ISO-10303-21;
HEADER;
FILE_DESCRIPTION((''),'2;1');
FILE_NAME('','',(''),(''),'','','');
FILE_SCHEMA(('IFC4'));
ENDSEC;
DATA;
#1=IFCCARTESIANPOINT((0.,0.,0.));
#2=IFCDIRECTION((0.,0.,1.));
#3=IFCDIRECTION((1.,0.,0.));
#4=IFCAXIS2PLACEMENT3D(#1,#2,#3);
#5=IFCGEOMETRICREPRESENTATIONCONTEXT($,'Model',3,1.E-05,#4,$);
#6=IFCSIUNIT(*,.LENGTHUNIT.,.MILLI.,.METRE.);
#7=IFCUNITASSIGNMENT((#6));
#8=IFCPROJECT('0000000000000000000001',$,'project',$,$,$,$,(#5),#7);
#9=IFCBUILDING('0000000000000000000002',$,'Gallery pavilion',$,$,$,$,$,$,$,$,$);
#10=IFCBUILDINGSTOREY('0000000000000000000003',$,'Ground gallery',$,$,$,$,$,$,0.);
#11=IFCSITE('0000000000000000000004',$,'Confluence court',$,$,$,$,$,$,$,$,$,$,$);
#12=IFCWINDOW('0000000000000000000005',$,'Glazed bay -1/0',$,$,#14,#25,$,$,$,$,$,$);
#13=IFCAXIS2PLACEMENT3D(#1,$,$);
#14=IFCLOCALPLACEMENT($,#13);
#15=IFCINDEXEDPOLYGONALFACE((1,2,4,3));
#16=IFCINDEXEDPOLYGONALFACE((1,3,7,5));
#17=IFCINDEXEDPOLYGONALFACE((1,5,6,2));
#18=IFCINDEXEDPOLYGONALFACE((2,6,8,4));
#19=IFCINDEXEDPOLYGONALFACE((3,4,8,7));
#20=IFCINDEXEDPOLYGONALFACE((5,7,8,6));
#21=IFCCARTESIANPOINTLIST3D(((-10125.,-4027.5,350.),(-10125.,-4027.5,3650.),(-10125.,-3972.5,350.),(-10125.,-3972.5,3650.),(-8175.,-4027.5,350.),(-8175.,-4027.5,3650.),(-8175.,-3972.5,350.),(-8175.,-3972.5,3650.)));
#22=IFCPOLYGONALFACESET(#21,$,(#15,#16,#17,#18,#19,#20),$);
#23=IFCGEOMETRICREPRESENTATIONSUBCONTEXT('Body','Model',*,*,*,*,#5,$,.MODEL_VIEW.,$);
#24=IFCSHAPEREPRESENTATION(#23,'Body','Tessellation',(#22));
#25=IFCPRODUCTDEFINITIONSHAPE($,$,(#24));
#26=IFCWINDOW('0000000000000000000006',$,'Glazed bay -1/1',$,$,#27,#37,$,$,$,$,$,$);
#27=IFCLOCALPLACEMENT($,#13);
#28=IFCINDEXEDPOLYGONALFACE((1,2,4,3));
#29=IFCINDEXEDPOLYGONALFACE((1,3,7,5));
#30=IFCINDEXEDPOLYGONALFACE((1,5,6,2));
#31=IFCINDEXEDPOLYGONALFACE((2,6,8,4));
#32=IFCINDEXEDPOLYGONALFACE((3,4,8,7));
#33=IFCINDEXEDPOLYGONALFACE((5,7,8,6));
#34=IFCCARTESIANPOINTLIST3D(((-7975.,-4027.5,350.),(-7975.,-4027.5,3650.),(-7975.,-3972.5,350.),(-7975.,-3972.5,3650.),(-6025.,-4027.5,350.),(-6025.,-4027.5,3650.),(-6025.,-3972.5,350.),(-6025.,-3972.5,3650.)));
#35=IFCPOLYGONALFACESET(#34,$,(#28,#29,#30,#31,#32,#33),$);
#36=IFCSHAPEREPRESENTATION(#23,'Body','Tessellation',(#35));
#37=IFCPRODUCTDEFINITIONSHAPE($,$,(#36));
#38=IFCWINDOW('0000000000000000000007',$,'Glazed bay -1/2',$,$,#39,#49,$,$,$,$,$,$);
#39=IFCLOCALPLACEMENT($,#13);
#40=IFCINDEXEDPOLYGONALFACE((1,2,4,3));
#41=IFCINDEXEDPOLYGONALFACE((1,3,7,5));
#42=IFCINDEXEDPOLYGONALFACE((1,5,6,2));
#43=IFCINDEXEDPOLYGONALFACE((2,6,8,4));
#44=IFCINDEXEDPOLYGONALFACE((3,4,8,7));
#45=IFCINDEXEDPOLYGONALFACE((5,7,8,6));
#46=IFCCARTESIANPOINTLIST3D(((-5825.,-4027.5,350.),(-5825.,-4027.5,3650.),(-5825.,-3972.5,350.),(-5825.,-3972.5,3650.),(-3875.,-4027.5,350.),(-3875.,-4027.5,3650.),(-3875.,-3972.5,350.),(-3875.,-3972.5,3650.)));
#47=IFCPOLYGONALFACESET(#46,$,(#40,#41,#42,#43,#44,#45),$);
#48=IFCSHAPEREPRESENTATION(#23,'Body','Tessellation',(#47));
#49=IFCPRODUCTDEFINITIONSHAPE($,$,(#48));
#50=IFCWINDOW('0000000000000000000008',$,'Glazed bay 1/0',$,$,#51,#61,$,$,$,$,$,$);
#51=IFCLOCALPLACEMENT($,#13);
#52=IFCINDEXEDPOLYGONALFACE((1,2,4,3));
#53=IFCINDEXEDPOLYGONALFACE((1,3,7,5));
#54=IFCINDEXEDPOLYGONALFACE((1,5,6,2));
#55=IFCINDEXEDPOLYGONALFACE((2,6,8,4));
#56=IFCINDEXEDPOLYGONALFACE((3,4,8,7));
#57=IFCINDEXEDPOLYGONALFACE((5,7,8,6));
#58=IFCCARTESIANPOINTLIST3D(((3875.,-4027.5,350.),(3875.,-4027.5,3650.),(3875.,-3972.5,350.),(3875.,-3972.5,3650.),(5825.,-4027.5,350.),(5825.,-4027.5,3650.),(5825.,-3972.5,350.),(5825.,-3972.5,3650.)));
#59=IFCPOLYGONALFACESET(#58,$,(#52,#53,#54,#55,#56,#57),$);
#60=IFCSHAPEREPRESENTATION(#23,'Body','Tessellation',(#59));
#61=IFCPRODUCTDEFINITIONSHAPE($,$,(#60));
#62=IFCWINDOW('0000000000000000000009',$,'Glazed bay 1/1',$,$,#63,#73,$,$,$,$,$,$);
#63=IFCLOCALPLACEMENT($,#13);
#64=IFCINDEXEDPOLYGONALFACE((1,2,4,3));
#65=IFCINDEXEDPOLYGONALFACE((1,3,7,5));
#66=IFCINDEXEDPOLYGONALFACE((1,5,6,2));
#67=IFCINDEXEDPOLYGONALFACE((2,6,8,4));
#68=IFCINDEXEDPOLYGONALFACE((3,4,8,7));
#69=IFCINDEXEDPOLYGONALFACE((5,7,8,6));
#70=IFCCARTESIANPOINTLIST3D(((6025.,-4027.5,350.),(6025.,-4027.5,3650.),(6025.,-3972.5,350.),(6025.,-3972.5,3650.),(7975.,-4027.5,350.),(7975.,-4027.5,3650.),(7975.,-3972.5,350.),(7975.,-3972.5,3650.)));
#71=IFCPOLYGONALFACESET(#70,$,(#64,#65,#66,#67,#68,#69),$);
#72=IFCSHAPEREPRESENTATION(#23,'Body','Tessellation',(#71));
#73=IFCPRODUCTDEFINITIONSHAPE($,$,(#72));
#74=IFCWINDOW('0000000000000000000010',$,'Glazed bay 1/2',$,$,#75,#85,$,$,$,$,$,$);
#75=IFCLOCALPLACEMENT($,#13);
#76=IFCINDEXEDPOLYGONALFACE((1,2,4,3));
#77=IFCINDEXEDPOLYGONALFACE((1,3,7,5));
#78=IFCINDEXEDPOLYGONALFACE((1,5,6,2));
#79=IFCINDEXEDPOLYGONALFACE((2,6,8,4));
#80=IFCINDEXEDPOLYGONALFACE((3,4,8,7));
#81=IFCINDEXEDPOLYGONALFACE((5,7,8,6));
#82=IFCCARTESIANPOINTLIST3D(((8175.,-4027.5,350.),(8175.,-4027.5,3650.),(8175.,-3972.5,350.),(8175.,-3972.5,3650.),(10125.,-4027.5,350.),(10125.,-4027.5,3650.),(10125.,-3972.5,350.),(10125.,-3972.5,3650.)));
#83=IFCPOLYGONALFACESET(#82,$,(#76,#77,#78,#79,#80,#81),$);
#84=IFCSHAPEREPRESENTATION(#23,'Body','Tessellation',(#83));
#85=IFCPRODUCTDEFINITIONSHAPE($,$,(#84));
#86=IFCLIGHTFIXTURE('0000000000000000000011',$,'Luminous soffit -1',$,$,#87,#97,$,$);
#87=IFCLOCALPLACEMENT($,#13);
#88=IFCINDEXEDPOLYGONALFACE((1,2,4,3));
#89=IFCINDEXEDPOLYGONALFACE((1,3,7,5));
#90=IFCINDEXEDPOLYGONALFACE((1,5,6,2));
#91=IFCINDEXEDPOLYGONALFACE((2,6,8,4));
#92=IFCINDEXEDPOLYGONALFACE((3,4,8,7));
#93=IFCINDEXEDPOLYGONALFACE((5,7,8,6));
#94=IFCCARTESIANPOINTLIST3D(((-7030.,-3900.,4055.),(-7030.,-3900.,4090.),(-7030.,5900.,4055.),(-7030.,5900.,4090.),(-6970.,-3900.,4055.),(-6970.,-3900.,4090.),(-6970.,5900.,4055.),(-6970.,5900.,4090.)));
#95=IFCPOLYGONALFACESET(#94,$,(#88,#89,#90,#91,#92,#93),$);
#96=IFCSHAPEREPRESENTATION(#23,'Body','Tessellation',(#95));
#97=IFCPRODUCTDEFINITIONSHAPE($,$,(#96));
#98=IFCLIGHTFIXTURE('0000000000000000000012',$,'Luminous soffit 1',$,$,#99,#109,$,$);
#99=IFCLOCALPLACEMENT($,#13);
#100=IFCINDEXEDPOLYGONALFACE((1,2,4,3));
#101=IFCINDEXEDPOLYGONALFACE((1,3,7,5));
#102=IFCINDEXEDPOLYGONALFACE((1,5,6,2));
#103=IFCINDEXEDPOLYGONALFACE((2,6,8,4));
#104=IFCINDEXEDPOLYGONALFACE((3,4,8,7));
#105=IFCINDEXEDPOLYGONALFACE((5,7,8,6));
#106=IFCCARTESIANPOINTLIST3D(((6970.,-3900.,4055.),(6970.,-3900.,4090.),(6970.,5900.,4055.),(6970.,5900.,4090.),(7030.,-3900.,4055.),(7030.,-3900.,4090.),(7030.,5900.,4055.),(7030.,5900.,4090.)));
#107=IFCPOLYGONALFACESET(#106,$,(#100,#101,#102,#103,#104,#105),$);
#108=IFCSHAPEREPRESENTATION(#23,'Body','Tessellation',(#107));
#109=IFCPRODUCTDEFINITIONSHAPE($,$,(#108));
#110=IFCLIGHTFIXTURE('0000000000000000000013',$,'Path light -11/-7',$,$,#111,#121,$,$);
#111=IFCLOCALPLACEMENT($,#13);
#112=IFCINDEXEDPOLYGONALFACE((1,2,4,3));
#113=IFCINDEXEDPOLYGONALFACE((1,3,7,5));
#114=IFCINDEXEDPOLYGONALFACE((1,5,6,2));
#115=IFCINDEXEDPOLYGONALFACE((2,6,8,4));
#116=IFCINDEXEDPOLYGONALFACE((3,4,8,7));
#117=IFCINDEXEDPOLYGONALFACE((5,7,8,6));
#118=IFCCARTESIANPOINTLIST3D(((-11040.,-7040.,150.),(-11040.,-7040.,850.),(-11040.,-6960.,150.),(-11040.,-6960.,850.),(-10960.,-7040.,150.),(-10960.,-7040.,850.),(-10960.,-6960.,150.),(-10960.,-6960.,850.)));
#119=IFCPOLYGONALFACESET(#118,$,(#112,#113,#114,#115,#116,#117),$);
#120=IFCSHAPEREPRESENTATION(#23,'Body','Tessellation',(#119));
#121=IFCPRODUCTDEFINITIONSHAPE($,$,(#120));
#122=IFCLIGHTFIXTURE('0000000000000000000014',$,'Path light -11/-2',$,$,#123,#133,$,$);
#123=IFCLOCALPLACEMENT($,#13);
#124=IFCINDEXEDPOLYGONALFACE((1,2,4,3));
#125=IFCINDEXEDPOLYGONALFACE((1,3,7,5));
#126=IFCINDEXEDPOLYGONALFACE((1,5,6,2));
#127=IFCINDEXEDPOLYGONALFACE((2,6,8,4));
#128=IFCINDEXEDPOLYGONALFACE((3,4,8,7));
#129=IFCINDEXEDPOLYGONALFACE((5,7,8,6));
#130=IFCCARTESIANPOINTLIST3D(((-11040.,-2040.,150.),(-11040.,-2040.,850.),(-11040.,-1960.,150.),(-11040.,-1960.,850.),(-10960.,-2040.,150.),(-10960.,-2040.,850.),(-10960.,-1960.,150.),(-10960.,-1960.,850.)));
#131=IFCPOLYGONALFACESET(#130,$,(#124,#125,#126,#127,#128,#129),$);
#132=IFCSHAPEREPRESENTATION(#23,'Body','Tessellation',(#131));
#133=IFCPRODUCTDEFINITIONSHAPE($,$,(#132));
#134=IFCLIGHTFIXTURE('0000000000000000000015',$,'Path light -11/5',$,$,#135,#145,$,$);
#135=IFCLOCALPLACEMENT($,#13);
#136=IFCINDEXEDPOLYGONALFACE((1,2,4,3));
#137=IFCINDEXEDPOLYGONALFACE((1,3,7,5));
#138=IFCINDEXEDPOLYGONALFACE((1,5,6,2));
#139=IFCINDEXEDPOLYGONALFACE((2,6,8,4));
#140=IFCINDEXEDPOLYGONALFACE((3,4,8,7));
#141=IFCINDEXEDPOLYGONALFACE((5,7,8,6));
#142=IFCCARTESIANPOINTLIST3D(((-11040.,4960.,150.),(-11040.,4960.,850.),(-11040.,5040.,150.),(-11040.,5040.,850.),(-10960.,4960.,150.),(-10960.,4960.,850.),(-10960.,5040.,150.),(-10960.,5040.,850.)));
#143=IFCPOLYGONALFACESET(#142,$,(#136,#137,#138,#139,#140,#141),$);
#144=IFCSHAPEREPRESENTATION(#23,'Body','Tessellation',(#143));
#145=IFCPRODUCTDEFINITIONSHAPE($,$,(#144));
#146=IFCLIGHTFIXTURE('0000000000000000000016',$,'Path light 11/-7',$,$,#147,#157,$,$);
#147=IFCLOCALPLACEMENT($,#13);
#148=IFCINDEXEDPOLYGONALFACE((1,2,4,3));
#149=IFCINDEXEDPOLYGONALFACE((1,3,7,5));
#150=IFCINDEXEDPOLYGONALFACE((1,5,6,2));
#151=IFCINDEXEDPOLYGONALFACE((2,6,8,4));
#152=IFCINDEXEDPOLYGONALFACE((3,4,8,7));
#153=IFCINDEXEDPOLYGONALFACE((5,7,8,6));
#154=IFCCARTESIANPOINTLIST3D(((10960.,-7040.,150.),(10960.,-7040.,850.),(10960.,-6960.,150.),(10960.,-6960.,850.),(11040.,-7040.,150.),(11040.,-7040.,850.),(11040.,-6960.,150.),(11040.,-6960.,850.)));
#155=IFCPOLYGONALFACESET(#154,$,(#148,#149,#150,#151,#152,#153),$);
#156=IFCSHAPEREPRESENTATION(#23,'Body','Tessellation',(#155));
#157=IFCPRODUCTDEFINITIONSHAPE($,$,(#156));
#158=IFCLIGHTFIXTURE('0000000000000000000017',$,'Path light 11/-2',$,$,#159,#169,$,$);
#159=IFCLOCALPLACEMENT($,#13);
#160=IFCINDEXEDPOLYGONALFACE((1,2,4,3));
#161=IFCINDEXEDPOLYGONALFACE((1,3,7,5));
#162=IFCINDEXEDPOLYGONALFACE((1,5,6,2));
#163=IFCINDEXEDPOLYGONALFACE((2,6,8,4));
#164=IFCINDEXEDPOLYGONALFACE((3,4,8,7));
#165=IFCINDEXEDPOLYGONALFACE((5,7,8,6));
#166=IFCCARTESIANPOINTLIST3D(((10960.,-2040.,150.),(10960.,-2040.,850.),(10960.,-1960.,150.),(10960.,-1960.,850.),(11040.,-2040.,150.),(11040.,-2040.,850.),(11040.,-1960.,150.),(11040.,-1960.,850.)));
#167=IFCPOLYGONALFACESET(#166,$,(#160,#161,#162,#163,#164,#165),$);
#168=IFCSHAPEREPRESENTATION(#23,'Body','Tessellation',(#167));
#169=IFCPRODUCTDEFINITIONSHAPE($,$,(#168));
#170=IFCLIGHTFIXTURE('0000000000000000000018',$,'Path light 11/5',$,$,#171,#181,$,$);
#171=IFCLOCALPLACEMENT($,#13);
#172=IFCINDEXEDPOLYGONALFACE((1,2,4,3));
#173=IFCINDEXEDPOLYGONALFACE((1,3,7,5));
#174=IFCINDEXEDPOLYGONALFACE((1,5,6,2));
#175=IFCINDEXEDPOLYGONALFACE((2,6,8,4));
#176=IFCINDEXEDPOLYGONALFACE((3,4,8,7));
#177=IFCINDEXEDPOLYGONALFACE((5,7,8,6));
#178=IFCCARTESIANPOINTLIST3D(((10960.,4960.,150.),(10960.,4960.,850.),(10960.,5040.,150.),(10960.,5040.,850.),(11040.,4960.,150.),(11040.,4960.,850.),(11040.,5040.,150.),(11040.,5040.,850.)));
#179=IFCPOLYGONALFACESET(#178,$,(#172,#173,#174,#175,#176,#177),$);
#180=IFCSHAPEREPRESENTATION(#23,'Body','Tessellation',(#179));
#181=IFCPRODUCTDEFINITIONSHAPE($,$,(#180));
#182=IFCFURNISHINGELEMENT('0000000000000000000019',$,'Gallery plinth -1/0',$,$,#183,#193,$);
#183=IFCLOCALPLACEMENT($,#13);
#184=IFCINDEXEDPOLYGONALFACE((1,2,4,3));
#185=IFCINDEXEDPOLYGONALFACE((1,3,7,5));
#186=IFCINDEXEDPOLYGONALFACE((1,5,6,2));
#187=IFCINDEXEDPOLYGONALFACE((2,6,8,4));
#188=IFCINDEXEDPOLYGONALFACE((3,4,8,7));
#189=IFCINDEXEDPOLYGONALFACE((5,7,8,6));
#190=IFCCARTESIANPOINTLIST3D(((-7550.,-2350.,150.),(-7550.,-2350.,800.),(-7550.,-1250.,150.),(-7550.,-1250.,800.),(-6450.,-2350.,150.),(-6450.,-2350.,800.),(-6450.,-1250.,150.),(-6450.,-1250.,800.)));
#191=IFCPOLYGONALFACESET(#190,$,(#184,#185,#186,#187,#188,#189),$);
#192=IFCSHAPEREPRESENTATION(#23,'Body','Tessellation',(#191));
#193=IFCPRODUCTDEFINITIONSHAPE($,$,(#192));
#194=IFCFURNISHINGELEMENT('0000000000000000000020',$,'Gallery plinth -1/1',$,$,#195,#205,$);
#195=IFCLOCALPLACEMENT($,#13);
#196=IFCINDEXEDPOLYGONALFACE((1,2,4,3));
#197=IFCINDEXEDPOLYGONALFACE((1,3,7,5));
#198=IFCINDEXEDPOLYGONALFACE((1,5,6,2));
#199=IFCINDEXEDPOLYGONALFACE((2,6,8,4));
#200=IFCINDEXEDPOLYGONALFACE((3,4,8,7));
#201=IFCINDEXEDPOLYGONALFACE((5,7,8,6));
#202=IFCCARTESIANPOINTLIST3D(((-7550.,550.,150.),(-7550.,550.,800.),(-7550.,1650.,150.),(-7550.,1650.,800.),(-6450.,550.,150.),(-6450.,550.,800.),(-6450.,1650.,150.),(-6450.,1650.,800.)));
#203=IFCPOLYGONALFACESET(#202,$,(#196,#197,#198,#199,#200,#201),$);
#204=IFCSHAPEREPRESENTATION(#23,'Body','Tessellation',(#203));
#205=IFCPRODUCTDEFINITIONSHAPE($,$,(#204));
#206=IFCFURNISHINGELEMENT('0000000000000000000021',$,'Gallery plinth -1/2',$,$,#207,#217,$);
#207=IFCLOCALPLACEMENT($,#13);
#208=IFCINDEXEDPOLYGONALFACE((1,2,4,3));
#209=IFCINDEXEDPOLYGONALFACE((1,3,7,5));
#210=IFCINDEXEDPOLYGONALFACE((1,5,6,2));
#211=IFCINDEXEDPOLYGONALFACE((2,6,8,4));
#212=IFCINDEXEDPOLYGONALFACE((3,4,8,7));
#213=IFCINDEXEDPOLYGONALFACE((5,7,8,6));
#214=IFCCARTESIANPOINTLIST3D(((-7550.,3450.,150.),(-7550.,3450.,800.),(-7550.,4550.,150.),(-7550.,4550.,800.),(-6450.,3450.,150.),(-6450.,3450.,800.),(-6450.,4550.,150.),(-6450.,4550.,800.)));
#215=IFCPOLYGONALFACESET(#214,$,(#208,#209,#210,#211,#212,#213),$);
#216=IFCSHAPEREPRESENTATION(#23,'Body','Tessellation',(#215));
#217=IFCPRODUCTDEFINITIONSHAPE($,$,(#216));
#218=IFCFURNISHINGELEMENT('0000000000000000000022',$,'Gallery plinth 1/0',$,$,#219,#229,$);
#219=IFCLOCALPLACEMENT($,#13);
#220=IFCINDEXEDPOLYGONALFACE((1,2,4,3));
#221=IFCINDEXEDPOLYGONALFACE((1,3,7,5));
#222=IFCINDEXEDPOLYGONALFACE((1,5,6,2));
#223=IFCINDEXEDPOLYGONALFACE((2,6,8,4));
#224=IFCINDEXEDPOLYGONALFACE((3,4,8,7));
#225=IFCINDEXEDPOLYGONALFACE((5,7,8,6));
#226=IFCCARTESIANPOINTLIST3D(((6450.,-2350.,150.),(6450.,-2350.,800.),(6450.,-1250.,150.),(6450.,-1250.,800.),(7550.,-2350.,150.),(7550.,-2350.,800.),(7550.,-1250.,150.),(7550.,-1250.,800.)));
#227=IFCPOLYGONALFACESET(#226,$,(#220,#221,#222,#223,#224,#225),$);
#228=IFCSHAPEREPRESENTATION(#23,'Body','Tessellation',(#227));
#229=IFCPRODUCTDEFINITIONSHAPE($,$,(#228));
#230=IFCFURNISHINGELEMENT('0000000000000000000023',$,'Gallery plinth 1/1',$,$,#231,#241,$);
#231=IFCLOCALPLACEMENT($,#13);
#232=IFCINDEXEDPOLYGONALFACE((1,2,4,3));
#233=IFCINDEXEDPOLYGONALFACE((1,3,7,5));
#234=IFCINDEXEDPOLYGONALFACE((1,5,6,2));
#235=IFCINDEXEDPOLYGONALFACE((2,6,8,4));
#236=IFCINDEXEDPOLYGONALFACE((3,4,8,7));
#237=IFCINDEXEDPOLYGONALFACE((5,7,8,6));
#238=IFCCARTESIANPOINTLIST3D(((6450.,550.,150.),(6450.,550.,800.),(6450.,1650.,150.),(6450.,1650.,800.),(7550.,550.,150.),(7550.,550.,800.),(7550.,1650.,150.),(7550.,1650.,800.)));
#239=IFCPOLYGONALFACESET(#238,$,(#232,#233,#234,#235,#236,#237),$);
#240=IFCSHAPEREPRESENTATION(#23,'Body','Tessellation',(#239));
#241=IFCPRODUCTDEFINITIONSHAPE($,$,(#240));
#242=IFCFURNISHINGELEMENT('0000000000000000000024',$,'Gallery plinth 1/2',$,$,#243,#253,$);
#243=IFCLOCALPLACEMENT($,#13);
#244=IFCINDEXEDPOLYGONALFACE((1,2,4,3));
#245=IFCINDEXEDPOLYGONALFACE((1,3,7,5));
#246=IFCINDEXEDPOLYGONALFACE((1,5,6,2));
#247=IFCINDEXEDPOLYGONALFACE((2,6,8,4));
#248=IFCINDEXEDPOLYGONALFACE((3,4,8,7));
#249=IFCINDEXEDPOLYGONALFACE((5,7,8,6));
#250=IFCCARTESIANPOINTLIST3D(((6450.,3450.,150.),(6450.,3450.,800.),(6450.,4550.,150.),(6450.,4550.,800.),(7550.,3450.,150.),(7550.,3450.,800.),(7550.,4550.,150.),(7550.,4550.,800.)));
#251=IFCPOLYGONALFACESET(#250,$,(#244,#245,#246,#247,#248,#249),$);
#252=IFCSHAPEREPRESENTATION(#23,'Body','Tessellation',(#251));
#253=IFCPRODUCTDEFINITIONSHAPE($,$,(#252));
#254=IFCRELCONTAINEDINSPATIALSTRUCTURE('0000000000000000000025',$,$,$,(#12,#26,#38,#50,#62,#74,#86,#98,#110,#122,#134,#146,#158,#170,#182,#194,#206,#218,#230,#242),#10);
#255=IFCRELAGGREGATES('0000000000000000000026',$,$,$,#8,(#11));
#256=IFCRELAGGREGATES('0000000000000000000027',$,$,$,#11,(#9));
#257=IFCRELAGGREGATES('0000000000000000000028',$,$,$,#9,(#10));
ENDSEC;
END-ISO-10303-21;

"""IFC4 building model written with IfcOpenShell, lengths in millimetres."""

from ifc_helpers import new_model, si_unit, frame, origin_with_axes, place, context, subcontext, project, spatial, rectangle, extrude, element, save


model = new_model("IFC4")

# Units and contexts
model_context = context("Model", 3, precision=1e-05, world=origin_with_axes())
body_context = subcontext(model_context, "Body", "Model", "MODEL_VIEW")
ifc_project = project(units=[si_unit("LENGTHUNIT", "METRE", prefix="MILLI")], contexts=[model_context])

# Site, building, storey
site = spatial("IfcSite", under=ifc_project, Name="Confluence court")
building = spatial("IfcBuilding", under=site, Name="Gallery pavilion")
storey = spatial("IfcBuildingStorey", under=building, Name="Ground gallery", Elevation=0.0)

# Windows
for number, where, z_axis, x_axis, name in (
    (1, (-9150.0, -4000.0, 350.0), (0.0, 0.0, 1.0), (1.0, 0.0, 0.0), "Glazed bay -1/0"),
    (2, (-7000.0, -4000.0, 350.0), (0.0, 0.0, 1.0), (1.0, 0.0, 0.0), "Glazed bay -1/1"),
    (3, (-4850.0, -4000.0, 350.0), (0.0, 0.0, 1.0), (1.0, 0.0, 0.0), "Glazed bay -1/2"),
    (4, (4850.0, -4000.0, 350.0), (0.0, 0.0, 1.0), (1.0, 0.0, 0.0), "Glazed bay 1/0"),
    (5, (7000.0, -4000.0, 350.0), (0.0, 0.0, 1.0), (1.0, 0.0, 0.0), "Glazed bay 1/1"),
    (6, (9150.0, -4000.0, 350.0), (0.0, 0.0, 1.0), (1.0, 0.0, 0.0), "Glazed bay 1/2"),
):
    element("IfcWindow", number, at=place(None, frame(where, z_axis=z_axis, x_axis=x_axis)), inside=storey, Name=name, context=body_context, shape_type="SweptSolid", body=[
        extrude(rectangle(XDim=1950.0, YDim=55.0), origin_with_axes(), (0.0, 0.0, 1.0), 3300.0),
    ])

# Light fixtures
for number, where, z_axis, x_axis, name in (
    (7, (-7000.0, 1000.0, 4055.0), (0.0, 0.0, 1.0), (1.0, 0.0, 0.0), "Luminous soffit -1"),
    (8, (7000.0, 1000.0, 4055.0), (0.0, 0.0, 1.0), (1.0, 0.0, 0.0), "Luminous soffit 1"),
):
    element("IfcLightFixture", number, at=place(None, frame(where, z_axis=z_axis, x_axis=x_axis)), inside=storey, Name=name, context=body_context, shape_type="SweptSolid", body=[
        extrude(rectangle(XDim=60.0, YDim=9800.0), origin_with_axes(), (0.0, 0.0, 1.0), 35.0),
    ])
for number, where, z_axis, x_axis, name in (
    (9, (-11000.0, -7000.0, 150.0), (0.0, 0.0, 1.0), (1.0, 0.0, 0.0), "Path light -11/-7"),
    (10, (-11000.0, -2000.0, 150.0), (0.0, 0.0, 1.0), (1.0, 0.0, 0.0), "Path light -11/-2"),
    (11, (-11000.0, 5000.0, 150.0), (0.0, 0.0, 1.0), (1.0, 0.0, 0.0), "Path light -11/5"),
    (12, (11000.0, -7000.0, 150.0), (0.0, 0.0, 1.0), (1.0, 0.0, 0.0), "Path light 11/-7"),
    (13, (11000.0, -2000.0, 150.0), (0.0, 0.0, 1.0), (1.0, 0.0, 0.0), "Path light 11/-2"),
    (14, (11000.0, 5000.0, 150.0), (0.0, 0.0, 1.0), (1.0, 0.0, 0.0), "Path light 11/5"),
):
    element("IfcLightFixture", number, at=place(None, frame(where, z_axis=z_axis, x_axis=x_axis)), inside=storey, Name=name, context=body_context, shape_type="SweptSolid", body=[
        extrude(rectangle(XDim=80.0, YDim=80.0), origin_with_axes(), (0.0, 0.0, 1.0), 700.0),
    ])

# Furnishing elements
for number, where, z_axis, x_axis, name in (
    (15, (-7000.0, -1800.0, 150.0), (0.0, 0.0, 1.0), (1.0, 0.0, 0.0), "Gallery plinth -1/0"),
    (16, (-7000.0, 1100.0, 150.0), (0.0, 0.0, 1.0), (1.0, 0.0, 0.0), "Gallery plinth -1/1"),
    (17, (-7000.0, 4000.0, 150.0), (0.0, 0.0, 1.0), (1.0, 0.0, 0.0), "Gallery plinth -1/2"),
    (18, (7000.0, -1800.0, 150.0), (0.0, 0.0, 1.0), (1.0, 0.0, 0.0), "Gallery plinth 1/0"),
    (19, (7000.0, 1100.0, 150.0), (0.0, 0.0, 1.0), (1.0, 0.0, 0.0), "Gallery plinth 1/1"),
    (20, (7000.0, 4000.0, 150.0), (0.0, 0.0, 1.0), (1.0, 0.0, 0.0), "Gallery plinth 1/2"),
):
    element("IfcFurnishingElement", number, at=place(None, frame(where, z_axis=z_axis, x_axis=x_axis)), inside=storey, Name=name, context=body_context, shape_type="SweptSolid", body=[
        extrude(rectangle(XDim=1100.0, YDim=1100.0), origin_with_axes(), (0.0, 0.0, 1.0), 650.0),
    ])

save(model, "model.ifc")
